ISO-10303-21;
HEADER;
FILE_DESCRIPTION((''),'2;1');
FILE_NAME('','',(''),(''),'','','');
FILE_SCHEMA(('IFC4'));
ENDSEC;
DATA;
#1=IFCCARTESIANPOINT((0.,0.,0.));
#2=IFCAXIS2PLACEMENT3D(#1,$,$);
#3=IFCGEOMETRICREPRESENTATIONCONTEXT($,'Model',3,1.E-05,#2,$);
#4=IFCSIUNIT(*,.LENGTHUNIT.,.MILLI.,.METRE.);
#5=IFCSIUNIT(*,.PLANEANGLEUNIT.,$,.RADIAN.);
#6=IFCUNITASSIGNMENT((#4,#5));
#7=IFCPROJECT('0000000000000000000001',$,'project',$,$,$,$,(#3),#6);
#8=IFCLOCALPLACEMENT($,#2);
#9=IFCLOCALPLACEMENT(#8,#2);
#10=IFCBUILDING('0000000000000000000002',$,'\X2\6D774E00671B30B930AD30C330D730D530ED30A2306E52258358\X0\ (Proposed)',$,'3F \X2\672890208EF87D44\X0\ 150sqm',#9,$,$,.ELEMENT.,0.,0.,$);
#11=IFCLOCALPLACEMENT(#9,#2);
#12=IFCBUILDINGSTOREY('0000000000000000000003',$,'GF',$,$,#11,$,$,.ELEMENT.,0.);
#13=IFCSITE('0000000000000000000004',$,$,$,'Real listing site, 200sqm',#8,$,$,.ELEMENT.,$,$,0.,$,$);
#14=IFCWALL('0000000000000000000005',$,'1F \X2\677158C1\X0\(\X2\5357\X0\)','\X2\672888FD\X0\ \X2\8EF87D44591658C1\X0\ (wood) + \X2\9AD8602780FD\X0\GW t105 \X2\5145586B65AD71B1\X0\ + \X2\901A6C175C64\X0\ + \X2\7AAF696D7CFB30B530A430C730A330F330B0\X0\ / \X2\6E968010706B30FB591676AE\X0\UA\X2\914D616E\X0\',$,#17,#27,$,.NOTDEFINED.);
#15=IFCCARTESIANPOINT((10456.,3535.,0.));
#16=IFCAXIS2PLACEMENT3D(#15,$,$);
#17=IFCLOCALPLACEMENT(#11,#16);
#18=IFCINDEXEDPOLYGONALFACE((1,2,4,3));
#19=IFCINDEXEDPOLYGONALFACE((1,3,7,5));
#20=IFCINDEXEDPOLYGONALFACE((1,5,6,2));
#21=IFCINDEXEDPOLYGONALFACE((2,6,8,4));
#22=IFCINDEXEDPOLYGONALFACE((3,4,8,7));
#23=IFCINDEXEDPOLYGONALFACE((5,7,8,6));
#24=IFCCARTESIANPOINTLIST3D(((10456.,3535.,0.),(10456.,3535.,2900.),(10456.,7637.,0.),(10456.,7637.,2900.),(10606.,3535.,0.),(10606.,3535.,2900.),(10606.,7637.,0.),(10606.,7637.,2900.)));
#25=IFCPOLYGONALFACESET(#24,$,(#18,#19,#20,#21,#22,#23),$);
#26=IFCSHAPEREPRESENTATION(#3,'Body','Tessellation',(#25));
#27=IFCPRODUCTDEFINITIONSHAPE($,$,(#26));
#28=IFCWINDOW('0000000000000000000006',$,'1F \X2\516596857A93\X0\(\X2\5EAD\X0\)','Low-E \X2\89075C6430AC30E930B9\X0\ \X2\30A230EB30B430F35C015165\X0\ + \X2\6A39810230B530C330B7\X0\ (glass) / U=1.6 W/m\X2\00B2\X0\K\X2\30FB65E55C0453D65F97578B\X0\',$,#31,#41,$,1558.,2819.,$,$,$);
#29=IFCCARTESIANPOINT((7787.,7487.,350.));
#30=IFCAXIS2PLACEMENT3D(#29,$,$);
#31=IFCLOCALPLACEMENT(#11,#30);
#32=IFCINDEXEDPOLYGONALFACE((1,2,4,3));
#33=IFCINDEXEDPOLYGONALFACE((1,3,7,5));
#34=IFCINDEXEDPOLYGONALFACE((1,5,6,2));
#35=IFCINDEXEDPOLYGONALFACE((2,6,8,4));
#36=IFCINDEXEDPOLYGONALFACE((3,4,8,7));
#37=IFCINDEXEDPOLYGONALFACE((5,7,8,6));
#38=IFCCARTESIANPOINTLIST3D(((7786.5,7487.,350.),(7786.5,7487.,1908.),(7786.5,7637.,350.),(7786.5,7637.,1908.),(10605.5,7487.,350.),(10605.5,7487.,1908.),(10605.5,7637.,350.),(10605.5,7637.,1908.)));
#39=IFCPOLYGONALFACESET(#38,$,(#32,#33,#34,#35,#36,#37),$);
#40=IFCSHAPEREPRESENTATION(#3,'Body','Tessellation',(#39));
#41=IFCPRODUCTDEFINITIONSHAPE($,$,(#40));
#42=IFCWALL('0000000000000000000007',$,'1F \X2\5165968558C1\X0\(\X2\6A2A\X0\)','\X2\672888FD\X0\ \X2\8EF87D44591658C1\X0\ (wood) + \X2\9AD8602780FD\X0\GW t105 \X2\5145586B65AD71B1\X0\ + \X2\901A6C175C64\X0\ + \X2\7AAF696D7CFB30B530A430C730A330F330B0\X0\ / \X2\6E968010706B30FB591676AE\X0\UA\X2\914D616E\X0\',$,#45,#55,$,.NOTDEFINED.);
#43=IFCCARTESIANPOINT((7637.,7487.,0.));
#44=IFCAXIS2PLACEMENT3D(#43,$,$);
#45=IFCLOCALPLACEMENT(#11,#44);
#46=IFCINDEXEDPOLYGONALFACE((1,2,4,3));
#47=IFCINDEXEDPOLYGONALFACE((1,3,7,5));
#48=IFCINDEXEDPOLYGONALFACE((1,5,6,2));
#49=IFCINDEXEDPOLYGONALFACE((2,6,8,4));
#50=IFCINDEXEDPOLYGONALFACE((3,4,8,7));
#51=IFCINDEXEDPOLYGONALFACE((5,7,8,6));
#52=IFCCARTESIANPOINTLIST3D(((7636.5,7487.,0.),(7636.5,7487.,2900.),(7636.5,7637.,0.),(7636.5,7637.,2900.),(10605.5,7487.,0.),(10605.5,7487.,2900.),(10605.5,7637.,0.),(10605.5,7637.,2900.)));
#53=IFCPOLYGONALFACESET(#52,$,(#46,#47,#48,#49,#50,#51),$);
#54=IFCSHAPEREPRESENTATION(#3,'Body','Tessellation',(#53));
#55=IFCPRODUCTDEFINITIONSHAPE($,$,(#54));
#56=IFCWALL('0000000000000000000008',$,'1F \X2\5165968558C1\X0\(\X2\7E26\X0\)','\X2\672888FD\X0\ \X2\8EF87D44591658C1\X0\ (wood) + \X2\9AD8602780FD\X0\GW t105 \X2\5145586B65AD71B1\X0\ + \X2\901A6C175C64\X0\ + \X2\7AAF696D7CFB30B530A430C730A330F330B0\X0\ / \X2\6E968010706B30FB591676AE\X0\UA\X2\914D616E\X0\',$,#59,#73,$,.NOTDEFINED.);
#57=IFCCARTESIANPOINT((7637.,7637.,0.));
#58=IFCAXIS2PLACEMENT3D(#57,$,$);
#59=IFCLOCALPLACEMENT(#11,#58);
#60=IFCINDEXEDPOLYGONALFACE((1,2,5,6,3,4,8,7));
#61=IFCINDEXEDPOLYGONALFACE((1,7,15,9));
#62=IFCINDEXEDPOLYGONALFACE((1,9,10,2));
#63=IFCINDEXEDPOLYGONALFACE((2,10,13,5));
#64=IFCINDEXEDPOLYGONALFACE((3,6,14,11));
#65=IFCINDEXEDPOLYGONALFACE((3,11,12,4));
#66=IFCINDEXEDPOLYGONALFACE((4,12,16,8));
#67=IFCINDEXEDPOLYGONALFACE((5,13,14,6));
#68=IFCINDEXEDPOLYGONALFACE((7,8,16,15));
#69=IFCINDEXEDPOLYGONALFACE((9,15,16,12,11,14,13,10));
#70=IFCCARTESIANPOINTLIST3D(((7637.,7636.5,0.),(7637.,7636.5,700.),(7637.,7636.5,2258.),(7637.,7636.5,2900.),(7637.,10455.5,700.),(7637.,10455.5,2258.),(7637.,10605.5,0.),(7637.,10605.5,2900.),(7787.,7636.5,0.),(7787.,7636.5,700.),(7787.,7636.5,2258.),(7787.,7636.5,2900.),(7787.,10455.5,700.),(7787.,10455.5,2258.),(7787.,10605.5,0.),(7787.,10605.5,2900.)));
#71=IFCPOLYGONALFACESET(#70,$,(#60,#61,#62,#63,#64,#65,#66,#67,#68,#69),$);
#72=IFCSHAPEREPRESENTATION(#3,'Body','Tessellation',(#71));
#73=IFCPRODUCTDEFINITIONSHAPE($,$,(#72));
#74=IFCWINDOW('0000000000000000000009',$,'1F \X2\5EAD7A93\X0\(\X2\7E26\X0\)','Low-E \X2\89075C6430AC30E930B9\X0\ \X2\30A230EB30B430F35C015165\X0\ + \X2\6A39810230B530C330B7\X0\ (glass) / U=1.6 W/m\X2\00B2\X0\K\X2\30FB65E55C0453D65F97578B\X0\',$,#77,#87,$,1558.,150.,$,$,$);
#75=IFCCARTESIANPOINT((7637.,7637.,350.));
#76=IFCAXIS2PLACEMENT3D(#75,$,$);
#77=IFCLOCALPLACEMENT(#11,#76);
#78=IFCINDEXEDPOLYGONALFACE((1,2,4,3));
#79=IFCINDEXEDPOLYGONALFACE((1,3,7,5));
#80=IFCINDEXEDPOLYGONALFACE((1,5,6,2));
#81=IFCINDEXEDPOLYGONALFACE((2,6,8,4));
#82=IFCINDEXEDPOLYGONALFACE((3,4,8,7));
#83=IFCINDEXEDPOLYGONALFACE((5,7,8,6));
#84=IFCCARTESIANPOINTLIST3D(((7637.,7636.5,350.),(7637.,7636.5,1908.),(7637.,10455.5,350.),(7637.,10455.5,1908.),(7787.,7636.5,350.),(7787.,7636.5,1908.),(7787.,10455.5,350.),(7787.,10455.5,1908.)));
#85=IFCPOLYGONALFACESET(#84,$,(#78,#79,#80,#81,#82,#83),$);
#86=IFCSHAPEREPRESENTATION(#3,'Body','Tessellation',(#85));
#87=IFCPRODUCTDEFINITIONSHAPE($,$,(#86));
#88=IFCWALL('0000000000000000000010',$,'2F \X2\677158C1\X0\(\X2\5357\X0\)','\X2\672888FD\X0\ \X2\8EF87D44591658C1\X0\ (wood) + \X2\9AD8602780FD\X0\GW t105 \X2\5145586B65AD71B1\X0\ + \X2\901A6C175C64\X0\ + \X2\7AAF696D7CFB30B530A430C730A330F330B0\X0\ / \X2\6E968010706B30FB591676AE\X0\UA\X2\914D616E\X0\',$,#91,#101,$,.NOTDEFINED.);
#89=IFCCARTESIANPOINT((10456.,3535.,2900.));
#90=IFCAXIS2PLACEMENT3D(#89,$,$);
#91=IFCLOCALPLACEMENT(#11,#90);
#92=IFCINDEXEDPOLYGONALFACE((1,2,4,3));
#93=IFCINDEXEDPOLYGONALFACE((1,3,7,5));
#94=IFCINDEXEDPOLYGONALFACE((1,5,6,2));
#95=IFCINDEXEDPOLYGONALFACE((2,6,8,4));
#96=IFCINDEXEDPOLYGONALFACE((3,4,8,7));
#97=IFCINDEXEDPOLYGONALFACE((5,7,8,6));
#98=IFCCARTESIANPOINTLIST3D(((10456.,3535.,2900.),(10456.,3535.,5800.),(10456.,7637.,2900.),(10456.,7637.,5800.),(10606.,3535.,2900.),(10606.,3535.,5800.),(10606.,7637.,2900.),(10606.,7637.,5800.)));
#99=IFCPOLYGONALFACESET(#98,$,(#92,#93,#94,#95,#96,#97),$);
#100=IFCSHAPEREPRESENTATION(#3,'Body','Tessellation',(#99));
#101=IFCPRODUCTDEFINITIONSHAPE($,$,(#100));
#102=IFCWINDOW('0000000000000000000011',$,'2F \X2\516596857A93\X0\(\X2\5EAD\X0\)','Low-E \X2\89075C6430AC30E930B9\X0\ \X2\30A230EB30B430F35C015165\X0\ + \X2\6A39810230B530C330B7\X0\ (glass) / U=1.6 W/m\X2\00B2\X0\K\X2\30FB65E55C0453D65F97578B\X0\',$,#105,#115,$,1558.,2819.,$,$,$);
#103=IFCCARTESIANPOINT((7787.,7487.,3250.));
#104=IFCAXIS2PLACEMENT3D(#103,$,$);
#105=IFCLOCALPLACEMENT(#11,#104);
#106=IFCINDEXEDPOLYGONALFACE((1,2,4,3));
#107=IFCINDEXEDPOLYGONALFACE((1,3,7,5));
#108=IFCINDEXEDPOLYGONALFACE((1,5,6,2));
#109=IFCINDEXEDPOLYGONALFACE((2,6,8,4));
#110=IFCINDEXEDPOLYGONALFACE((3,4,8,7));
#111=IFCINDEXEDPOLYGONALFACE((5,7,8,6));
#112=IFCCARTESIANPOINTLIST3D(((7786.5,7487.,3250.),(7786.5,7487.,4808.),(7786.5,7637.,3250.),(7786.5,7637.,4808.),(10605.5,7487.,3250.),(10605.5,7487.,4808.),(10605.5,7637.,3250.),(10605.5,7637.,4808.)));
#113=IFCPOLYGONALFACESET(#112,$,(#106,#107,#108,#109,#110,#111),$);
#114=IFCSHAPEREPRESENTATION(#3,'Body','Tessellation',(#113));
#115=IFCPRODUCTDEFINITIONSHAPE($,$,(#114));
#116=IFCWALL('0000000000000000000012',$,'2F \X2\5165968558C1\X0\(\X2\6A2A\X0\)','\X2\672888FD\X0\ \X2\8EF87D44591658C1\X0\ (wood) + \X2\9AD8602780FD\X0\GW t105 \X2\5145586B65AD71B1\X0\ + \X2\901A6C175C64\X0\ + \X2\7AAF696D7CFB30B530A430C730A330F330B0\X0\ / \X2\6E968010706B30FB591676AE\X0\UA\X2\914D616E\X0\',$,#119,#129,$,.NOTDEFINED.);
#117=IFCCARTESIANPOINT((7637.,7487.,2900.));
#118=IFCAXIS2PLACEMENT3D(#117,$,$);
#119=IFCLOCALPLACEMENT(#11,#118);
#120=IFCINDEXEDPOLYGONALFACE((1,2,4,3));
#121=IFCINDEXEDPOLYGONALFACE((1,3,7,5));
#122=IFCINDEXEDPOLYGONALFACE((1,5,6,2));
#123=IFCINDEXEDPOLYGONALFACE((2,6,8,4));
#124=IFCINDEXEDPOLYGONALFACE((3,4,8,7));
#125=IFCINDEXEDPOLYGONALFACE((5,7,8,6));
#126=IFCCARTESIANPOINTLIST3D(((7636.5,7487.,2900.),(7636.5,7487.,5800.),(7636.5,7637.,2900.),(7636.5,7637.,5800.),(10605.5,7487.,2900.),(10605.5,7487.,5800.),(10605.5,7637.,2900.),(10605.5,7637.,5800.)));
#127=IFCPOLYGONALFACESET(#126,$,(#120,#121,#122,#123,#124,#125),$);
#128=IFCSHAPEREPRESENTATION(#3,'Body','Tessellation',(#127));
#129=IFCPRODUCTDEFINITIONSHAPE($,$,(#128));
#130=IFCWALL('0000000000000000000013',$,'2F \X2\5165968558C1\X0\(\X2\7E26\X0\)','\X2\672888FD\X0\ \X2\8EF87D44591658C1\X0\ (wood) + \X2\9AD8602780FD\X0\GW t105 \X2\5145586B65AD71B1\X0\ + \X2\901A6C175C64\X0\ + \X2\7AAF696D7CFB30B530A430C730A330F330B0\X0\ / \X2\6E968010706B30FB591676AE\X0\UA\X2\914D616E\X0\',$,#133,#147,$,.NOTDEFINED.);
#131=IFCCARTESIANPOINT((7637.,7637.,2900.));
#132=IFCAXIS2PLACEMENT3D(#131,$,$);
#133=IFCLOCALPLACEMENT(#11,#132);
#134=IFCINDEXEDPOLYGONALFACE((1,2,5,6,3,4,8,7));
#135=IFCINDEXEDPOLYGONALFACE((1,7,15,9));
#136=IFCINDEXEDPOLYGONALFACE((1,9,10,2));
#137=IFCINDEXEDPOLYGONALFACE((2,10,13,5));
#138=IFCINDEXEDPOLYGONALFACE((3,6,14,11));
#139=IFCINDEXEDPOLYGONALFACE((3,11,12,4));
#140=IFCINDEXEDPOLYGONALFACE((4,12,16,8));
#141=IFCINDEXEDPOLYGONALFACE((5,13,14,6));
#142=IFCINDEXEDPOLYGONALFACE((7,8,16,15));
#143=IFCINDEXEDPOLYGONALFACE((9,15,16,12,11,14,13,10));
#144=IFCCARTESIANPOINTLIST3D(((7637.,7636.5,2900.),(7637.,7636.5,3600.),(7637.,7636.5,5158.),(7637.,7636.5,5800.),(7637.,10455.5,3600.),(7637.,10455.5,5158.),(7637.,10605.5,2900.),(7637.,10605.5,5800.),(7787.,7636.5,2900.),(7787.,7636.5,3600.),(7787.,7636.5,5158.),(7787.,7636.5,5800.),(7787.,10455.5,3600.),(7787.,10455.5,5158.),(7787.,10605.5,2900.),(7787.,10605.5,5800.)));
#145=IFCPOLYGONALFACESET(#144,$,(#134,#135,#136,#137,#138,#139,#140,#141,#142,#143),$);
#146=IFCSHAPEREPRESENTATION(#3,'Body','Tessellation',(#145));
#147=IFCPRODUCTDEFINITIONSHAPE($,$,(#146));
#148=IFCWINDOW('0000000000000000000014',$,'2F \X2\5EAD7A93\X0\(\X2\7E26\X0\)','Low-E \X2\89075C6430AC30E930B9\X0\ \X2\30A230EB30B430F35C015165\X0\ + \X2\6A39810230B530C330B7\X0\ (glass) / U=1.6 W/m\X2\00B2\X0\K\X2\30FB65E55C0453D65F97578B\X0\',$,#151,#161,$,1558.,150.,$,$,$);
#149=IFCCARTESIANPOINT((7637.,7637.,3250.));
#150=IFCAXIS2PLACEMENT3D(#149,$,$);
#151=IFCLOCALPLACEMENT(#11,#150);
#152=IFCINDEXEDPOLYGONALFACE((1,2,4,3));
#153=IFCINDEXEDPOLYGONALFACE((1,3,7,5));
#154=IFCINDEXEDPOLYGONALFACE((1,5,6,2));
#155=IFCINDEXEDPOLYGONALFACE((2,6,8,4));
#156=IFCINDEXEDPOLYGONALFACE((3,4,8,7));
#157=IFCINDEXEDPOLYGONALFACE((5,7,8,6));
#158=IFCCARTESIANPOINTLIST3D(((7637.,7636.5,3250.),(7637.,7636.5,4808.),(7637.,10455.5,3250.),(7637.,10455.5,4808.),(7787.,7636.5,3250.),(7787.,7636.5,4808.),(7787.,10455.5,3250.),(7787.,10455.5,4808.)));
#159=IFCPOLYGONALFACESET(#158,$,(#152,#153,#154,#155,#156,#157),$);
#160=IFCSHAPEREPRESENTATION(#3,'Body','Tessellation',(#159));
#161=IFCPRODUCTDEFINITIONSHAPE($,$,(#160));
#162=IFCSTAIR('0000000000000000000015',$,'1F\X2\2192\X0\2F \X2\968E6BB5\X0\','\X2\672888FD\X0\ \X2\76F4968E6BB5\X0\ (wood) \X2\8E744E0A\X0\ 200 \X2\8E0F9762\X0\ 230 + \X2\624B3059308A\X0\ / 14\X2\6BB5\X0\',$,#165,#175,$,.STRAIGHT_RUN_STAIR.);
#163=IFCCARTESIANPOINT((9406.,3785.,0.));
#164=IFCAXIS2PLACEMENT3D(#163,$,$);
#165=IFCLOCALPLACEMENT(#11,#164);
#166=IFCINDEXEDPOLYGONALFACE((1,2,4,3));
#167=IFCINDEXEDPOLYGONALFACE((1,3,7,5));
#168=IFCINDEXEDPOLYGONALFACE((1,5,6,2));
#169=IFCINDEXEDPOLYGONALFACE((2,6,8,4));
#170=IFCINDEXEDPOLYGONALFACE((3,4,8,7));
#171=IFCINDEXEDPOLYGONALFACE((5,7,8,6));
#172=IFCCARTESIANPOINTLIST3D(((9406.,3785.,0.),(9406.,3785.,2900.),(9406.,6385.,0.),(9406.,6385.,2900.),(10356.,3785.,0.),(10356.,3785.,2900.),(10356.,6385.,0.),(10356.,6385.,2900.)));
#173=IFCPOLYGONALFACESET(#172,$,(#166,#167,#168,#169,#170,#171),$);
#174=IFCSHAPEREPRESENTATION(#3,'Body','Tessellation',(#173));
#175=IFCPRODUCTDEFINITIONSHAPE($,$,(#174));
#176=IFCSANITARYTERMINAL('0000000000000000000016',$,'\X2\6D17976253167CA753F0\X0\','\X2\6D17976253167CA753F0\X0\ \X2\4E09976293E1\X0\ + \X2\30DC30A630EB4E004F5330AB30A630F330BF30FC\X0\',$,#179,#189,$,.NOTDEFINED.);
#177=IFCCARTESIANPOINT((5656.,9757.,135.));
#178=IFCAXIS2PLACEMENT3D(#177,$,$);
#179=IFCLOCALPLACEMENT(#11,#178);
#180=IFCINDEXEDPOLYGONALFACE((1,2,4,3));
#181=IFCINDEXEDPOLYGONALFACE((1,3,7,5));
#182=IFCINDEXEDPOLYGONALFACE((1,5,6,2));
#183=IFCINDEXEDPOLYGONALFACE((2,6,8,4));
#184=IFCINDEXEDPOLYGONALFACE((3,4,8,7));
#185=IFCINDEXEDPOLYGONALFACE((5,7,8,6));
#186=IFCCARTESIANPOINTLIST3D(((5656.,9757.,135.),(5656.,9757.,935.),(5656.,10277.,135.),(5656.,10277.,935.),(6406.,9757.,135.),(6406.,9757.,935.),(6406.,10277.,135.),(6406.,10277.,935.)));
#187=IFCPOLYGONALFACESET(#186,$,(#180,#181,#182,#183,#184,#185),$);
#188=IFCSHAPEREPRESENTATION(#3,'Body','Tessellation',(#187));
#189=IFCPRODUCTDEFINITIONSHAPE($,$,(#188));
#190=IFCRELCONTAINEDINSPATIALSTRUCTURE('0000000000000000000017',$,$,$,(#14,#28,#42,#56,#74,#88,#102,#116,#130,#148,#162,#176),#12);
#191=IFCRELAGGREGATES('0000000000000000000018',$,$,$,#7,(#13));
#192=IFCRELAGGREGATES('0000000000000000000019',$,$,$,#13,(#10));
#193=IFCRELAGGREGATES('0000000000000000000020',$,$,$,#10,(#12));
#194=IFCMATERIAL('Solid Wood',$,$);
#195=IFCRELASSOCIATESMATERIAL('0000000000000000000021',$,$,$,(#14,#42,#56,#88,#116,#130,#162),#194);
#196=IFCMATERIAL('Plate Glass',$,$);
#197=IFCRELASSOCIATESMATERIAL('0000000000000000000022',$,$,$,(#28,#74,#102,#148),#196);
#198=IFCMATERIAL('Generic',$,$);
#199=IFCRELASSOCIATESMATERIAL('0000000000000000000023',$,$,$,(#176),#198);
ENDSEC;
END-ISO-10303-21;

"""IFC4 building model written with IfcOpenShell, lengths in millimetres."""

from ifc_helpers import new_model, si_unit, frame, frame_2d, origin, place, context, project, spatial, rectangle, extrude, material, element, fill, save


model = new_model("IFC4")

# Units and contexts
model_context = context("Model", 3, precision=1e-05, world=origin())
ifc_project = project(units=[si_unit("LENGTHUNIT", "METRE", prefix="MILLI"), si_unit("PLANEANGLEUNIT", "RADIAN")], contexts=[model_context])

# Site, building, storey
site_placement = place(None, origin())
site = spatial("IfcSite", under=ifc_project, at=site_placement, ObjectType="Real listing site, 200sqm", CompositionType="ELEMENT", RefElevation=0.0)
building_placement = place(site_placement, origin())
building = spatial("IfcBuilding", under=site, at=building_placement, Name="海一望スキップフロアの別荘 (Proposed)", ObjectType="3F 木造軸組 150sqm", CompositionType="ELEMENT", ElevationOfRefHeight=0.0, ElevationOfTerrain=0.0)
storey_placement = place(building_placement, origin())
storey = spatial("IfcBuildingStorey", under=building, at=storey_placement, Name="GF", CompositionType="ELEMENT", Elevation=0.0)

# Shared definitions
ifc_material_1 = material(Name="Solid Wood")

# Wall, opening, window
wall_1_placement = place(storey_placement, frame((10456.0, 3535.0, 0.0)))
wall_1 = element("IfcWall", 1, at=wall_1_placement, inside=storey, material=ifc_material_1, Name="1F 東壁(南)", Description="木製 軸組外壁 (wood) + 高性能GW t105 充填断熱 + 通気層 + 窯業系サイディング / 準耐火・外皮UA配慮", PredefinedType="NOTDEFINED", context=model_context, shape_type="SweptSolid", body=[
    extrude(rectangle(XDim=150.0, YDim=4102.0, at=frame_2d((75.0, 2051.0))), frame((10456.0, 3535.0, 0.0)), (0.0, 0.0, 1.0), 2900.0),
])
opening_1_placement = place(storey_placement, frame((7787.0, 7487.0, 350.0)))
opening_1 = element("IfcOpeningElement", 2, at=opening_1_placement, cuts=wall_1, PredefinedType="NOTDEFINED", context=model_context, shape_type="SweptSolid", body=[
    extrude(rectangle(XDim=2819.0, YDim=150.0, at=frame_2d((1409.0, 75.0))), frame((7787.0, 7487.0, 350.0)), (0.0, 0.0, 1.0), 1558.0),
])
ifc_material_2 = material(Name="Plate Glass")
window_1_placement = place(storey_placement, frame((7787.0, 7487.0, 350.0)))
window_1 = element("IfcWindow", 3, at=window_1_placement, inside=storey, material=ifc_material_2, Name="1F 入隅窓(庭)", Description="Low-E 複層ガラス アルゴン封入 + 樹脂サッシ (glass) / U=1.6 W/m²K・日射取得型", OverallHeight=1558.0, OverallWidth=2819.0, context=model_context, shape_type="SweptSolid", body=[
    extrude(rectangle(XDim=2819.0, YDim=150.0, at=frame_2d((1409.0, 75.0))), frame((7787.0, 7487.0, 350.0)), (0.0, 0.0, 1.0), 1558.0),
])
fill(opening_1, window_1)

# Wall
wall_2_placement = place(storey_placement, frame((7637.0, 7487.0, 0.0)))
element("IfcWall", 4, at=wall_2_placement, inside=storey, material=ifc_material_1, Name="1F 入隅壁(横)", Description="木製 軸組外壁 (wood) + 高性能GW t105 充填断熱 + 通気層 + 窯業系サイディング / 準耐火・外皮UA配慮", PredefinedType="NOTDEFINED", context=model_context, shape_type="SweptSolid", body=[
    extrude(rectangle(XDim=2969.0, YDim=150.0, at=frame_2d((1484.0, 75.0))), frame((7637.0, 7487.0, 0.0)), (0.0, 0.0, 1.0), 2900.0),
])

# Wall, opening, window
wall_3_placement = place(storey_placement, frame((7637.0, 7637.0, 0.0)))
wall_3 = element("IfcWall", 5, at=wall_3_placement, inside=storey, material=ifc_material_1, Name="1F 入隅壁(縦)", Description="木製 軸組外壁 (wood) + 高性能GW t105 充填断熱 + 通気層 + 窯業系サイディング / 準耐火・外皮UA配慮", PredefinedType="NOTDEFINED", context=model_context, shape_type="SweptSolid", body=[
    extrude(rectangle(XDim=150.0, YDim=2969.0, at=frame_2d((75.0, 1484.0))), frame((7637.0, 7637.0, 0.0)), (0.0, 0.0, 1.0), 2900.0),
])
opening_2_placement = place(storey_placement, frame((7637.0, 7637.0, 350.0)))
opening_2 = element("IfcOpeningElement", 6, at=opening_2_placement, cuts=wall_3, PredefinedType="NOTDEFINED", context=model_context, shape_type="SweptSolid", body=[
    extrude(rectangle(XDim=150.0, YDim=2819.0, at=frame_2d((75.0, 1409.0))), frame((7637.0, 7637.0, 350.0)), (0.0, 0.0, 1.0), 1558.0),
])
window_2_placement = place(storey_placement, frame((7637.0, 7637.0, 350.0)))
window_2 = element("IfcWindow", 7, at=window_2_placement, inside=storey, material=ifc_material_2, Name="1F 庭窓(縦)", Description="Low-E 複層ガラス アルゴン封入 + 樹脂サッシ (glass) / U=1.6 W/m²K・日射取得型", OverallHeight=1558.0, OverallWidth=150.0, context=model_context, shape_type="SweptSolid", body=[
    extrude(rectangle(XDim=150.0, YDim=2819.0, at=frame_2d((75.0, 1409.0))), frame((7637.0, 7637.0, 350.0)), (0.0, 0.0, 1.0), 1558.0),
])
fill(opening_2, window_2)

# Wall, opening, window
wall_4_placement = place(storey_placement, frame((10456.0, 3535.0, 2900.0)))
wall_4 = element("IfcWall", 8, at=wall_4_placement, inside=storey, material=ifc_material_1, Name="2F 東壁(南)", Description="木製 軸組外壁 (wood) + 高性能GW t105 充填断熱 + 通気層 + 窯業系サイディング / 準耐火・外皮UA配慮", PredefinedType="NOTDEFINED", context=model_context, shape_type="SweptSolid", body=[
    extrude(rectangle(XDim=150.0, YDim=4102.0, at=frame_2d((75.0, 2051.0))), frame((10456.0, 3535.0, 2900.0)), (0.0, 0.0, 1.0), 2900.0),
])
opening_3_placement = place(storey_placement, frame((7787.0, 7487.0, 3250.0)))
opening_3 = element("IfcOpeningElement", 9, at=opening_3_placement, cuts=wall_4, PredefinedType="NOTDEFINED", context=model_context, shape_type="SweptSolid", body=[
    extrude(rectangle(XDim=2819.0, YDim=150.0, at=frame_2d((1409.0, 75.0))), frame((7787.0, 7487.0, 3250.0)), (0.0, 0.0, 1.0), 1558.0),
])
window_3_placement = place(storey_placement, frame((7787.0, 7487.0, 3250.0)))
window_3 = element("IfcWindow", 10, at=window_3_placement, inside=storey, material=ifc_material_2, Name="2F 入隅窓(庭)", Description="Low-E 複層ガラス アルゴン封入 + 樹脂サッシ (glass) / U=1.6 W/m²K・日射取得型", OverallHeight=1558.0, OverallWidth=2819.0, context=model_context, shape_type="SweptSolid", body=[
    extrude(rectangle(XDim=2819.0, YDim=150.0, at=frame_2d((1409.0, 75.0))), frame((7787.0, 7487.0, 3250.0)), (0.0, 0.0, 1.0), 1558.0),
])
fill(opening_3, window_3)

# Wall
wall_5_placement = place(storey_placement, frame((7637.0, 7487.0, 2900.0)))
element("IfcWall", 11, at=wall_5_placement, inside=storey, material=ifc_material_1, Name="2F 入隅壁(横)", Description="木製 軸組外壁 (wood) + 高性能GW t105 充填断熱 + 通気層 + 窯業系サイディング / 準耐火・外皮UA配慮", PredefinedType="NOTDEFINED", context=model_context, shape_type="SweptSolid", body=[
    extrude(rectangle(XDim=2969.0, YDim=150.0, at=frame_2d((1484.0, 75.0))), frame((7637.0, 7487.0, 2900.0)), (0.0, 0.0, 1.0), 2900.0),
])

# Wall, opening, window
wall_6_placement = place(storey_placement, frame((7637.0, 7637.0, 2900.0)))
wall_6 = element("IfcWall", 12, at=wall_6_placement, inside=storey, material=ifc_material_1, Name="2F 入隅壁(縦)", Description="木製 軸組外壁 (wood) + 高性能GW t105 充填断熱 + 通気層 + 窯業系サイディング / 準耐火・外皮UA配慮", PredefinedType="NOTDEFINED", context=model_context, shape_type="SweptSolid", body=[
    extrude(rectangle(XDim=150.0, YDim=2969.0, at=frame_2d((75.0, 1484.0))), frame((7637.0, 7637.0, 2900.0)), (0.0, 0.0, 1.0), 2900.0),
])
opening_4_placement = place(storey_placement, frame((7637.0, 7637.0, 3250.0)))
opening_4 = element("IfcOpeningElement", 13, at=opening_4_placement, cuts=wall_6, PredefinedType="NOTDEFINED", context=model_context, shape_type="SweptSolid", body=[
    extrude(rectangle(XDim=150.0, YDim=2819.0, at=frame_2d((75.0, 1409.0))), frame((7637.0, 7637.0, 3250.0)), (0.0, 0.0, 1.0), 1558.0),
])
window_4_placement = place(storey_placement, frame((7637.0, 7637.0, 3250.0)))
window_4 = element("IfcWindow", 14, at=window_4_placement, inside=storey, material=ifc_material_2, Name="2F 庭窓(縦)", Description="Low-E 複層ガラス アルゴン封入 + 樹脂サッシ (glass) / U=1.6 W/m²K・日射取得型", OverallHeight=1558.0, OverallWidth=150.0, context=model_context, shape_type="SweptSolid", body=[
    extrude(rectangle(XDim=150.0, YDim=2819.0, at=frame_2d((75.0, 1409.0))), frame((7637.0, 7637.0, 3250.0)), (0.0, 0.0, 1.0), 1558.0),
])
fill(opening_4, window_4)

# Stair
stair_placement = place(storey_placement, frame((9406.0, 3785.0, 0.0)))
element("IfcStair", 15, at=stair_placement, inside=storey, material=ifc_material_1, Name="1F→2F 階段", Description="木製 直階段 (wood) 蹴上 200 踏面 230 + 手すり / 14段", PredefinedType="STRAIGHT_RUN_STAIR", context=model_context, shape_type="SweptSolid", body=[
    extrude(rectangle(XDim=950.0, YDim=2600.0, at=frame_2d((475.0, 1300.0))), frame((9406.0, 3785.0, 0.0)), (0.0, 0.0, 1.0), 2900.0),
])

# Sanitary terminal
ifc_material_3 = material(Name="Generic")
sanitary_terminal_1_placement = place(storey_placement, frame((5656.0, 9757.0, 135.0)))
element("IfcSanitaryTerminal", 16, at=sanitary_terminal_1_placement, inside=storey, material=ifc_material_3, Name="洗面化粧台", Description="洗面化粧台 三面鏡 + ボウル一体カウンター", PredefinedType="NOTDEFINED", context=model_context, shape_type="SweptSolid", body=[
    extrude(rectangle(XDim=750.0, YDim=520.0, at=frame_2d((375.0, 260.0))), frame((5656.0, 9757.0, 135.0)), (0.0, 0.0, 1.0), 800.0),
])

save(model, "model.ifc")
